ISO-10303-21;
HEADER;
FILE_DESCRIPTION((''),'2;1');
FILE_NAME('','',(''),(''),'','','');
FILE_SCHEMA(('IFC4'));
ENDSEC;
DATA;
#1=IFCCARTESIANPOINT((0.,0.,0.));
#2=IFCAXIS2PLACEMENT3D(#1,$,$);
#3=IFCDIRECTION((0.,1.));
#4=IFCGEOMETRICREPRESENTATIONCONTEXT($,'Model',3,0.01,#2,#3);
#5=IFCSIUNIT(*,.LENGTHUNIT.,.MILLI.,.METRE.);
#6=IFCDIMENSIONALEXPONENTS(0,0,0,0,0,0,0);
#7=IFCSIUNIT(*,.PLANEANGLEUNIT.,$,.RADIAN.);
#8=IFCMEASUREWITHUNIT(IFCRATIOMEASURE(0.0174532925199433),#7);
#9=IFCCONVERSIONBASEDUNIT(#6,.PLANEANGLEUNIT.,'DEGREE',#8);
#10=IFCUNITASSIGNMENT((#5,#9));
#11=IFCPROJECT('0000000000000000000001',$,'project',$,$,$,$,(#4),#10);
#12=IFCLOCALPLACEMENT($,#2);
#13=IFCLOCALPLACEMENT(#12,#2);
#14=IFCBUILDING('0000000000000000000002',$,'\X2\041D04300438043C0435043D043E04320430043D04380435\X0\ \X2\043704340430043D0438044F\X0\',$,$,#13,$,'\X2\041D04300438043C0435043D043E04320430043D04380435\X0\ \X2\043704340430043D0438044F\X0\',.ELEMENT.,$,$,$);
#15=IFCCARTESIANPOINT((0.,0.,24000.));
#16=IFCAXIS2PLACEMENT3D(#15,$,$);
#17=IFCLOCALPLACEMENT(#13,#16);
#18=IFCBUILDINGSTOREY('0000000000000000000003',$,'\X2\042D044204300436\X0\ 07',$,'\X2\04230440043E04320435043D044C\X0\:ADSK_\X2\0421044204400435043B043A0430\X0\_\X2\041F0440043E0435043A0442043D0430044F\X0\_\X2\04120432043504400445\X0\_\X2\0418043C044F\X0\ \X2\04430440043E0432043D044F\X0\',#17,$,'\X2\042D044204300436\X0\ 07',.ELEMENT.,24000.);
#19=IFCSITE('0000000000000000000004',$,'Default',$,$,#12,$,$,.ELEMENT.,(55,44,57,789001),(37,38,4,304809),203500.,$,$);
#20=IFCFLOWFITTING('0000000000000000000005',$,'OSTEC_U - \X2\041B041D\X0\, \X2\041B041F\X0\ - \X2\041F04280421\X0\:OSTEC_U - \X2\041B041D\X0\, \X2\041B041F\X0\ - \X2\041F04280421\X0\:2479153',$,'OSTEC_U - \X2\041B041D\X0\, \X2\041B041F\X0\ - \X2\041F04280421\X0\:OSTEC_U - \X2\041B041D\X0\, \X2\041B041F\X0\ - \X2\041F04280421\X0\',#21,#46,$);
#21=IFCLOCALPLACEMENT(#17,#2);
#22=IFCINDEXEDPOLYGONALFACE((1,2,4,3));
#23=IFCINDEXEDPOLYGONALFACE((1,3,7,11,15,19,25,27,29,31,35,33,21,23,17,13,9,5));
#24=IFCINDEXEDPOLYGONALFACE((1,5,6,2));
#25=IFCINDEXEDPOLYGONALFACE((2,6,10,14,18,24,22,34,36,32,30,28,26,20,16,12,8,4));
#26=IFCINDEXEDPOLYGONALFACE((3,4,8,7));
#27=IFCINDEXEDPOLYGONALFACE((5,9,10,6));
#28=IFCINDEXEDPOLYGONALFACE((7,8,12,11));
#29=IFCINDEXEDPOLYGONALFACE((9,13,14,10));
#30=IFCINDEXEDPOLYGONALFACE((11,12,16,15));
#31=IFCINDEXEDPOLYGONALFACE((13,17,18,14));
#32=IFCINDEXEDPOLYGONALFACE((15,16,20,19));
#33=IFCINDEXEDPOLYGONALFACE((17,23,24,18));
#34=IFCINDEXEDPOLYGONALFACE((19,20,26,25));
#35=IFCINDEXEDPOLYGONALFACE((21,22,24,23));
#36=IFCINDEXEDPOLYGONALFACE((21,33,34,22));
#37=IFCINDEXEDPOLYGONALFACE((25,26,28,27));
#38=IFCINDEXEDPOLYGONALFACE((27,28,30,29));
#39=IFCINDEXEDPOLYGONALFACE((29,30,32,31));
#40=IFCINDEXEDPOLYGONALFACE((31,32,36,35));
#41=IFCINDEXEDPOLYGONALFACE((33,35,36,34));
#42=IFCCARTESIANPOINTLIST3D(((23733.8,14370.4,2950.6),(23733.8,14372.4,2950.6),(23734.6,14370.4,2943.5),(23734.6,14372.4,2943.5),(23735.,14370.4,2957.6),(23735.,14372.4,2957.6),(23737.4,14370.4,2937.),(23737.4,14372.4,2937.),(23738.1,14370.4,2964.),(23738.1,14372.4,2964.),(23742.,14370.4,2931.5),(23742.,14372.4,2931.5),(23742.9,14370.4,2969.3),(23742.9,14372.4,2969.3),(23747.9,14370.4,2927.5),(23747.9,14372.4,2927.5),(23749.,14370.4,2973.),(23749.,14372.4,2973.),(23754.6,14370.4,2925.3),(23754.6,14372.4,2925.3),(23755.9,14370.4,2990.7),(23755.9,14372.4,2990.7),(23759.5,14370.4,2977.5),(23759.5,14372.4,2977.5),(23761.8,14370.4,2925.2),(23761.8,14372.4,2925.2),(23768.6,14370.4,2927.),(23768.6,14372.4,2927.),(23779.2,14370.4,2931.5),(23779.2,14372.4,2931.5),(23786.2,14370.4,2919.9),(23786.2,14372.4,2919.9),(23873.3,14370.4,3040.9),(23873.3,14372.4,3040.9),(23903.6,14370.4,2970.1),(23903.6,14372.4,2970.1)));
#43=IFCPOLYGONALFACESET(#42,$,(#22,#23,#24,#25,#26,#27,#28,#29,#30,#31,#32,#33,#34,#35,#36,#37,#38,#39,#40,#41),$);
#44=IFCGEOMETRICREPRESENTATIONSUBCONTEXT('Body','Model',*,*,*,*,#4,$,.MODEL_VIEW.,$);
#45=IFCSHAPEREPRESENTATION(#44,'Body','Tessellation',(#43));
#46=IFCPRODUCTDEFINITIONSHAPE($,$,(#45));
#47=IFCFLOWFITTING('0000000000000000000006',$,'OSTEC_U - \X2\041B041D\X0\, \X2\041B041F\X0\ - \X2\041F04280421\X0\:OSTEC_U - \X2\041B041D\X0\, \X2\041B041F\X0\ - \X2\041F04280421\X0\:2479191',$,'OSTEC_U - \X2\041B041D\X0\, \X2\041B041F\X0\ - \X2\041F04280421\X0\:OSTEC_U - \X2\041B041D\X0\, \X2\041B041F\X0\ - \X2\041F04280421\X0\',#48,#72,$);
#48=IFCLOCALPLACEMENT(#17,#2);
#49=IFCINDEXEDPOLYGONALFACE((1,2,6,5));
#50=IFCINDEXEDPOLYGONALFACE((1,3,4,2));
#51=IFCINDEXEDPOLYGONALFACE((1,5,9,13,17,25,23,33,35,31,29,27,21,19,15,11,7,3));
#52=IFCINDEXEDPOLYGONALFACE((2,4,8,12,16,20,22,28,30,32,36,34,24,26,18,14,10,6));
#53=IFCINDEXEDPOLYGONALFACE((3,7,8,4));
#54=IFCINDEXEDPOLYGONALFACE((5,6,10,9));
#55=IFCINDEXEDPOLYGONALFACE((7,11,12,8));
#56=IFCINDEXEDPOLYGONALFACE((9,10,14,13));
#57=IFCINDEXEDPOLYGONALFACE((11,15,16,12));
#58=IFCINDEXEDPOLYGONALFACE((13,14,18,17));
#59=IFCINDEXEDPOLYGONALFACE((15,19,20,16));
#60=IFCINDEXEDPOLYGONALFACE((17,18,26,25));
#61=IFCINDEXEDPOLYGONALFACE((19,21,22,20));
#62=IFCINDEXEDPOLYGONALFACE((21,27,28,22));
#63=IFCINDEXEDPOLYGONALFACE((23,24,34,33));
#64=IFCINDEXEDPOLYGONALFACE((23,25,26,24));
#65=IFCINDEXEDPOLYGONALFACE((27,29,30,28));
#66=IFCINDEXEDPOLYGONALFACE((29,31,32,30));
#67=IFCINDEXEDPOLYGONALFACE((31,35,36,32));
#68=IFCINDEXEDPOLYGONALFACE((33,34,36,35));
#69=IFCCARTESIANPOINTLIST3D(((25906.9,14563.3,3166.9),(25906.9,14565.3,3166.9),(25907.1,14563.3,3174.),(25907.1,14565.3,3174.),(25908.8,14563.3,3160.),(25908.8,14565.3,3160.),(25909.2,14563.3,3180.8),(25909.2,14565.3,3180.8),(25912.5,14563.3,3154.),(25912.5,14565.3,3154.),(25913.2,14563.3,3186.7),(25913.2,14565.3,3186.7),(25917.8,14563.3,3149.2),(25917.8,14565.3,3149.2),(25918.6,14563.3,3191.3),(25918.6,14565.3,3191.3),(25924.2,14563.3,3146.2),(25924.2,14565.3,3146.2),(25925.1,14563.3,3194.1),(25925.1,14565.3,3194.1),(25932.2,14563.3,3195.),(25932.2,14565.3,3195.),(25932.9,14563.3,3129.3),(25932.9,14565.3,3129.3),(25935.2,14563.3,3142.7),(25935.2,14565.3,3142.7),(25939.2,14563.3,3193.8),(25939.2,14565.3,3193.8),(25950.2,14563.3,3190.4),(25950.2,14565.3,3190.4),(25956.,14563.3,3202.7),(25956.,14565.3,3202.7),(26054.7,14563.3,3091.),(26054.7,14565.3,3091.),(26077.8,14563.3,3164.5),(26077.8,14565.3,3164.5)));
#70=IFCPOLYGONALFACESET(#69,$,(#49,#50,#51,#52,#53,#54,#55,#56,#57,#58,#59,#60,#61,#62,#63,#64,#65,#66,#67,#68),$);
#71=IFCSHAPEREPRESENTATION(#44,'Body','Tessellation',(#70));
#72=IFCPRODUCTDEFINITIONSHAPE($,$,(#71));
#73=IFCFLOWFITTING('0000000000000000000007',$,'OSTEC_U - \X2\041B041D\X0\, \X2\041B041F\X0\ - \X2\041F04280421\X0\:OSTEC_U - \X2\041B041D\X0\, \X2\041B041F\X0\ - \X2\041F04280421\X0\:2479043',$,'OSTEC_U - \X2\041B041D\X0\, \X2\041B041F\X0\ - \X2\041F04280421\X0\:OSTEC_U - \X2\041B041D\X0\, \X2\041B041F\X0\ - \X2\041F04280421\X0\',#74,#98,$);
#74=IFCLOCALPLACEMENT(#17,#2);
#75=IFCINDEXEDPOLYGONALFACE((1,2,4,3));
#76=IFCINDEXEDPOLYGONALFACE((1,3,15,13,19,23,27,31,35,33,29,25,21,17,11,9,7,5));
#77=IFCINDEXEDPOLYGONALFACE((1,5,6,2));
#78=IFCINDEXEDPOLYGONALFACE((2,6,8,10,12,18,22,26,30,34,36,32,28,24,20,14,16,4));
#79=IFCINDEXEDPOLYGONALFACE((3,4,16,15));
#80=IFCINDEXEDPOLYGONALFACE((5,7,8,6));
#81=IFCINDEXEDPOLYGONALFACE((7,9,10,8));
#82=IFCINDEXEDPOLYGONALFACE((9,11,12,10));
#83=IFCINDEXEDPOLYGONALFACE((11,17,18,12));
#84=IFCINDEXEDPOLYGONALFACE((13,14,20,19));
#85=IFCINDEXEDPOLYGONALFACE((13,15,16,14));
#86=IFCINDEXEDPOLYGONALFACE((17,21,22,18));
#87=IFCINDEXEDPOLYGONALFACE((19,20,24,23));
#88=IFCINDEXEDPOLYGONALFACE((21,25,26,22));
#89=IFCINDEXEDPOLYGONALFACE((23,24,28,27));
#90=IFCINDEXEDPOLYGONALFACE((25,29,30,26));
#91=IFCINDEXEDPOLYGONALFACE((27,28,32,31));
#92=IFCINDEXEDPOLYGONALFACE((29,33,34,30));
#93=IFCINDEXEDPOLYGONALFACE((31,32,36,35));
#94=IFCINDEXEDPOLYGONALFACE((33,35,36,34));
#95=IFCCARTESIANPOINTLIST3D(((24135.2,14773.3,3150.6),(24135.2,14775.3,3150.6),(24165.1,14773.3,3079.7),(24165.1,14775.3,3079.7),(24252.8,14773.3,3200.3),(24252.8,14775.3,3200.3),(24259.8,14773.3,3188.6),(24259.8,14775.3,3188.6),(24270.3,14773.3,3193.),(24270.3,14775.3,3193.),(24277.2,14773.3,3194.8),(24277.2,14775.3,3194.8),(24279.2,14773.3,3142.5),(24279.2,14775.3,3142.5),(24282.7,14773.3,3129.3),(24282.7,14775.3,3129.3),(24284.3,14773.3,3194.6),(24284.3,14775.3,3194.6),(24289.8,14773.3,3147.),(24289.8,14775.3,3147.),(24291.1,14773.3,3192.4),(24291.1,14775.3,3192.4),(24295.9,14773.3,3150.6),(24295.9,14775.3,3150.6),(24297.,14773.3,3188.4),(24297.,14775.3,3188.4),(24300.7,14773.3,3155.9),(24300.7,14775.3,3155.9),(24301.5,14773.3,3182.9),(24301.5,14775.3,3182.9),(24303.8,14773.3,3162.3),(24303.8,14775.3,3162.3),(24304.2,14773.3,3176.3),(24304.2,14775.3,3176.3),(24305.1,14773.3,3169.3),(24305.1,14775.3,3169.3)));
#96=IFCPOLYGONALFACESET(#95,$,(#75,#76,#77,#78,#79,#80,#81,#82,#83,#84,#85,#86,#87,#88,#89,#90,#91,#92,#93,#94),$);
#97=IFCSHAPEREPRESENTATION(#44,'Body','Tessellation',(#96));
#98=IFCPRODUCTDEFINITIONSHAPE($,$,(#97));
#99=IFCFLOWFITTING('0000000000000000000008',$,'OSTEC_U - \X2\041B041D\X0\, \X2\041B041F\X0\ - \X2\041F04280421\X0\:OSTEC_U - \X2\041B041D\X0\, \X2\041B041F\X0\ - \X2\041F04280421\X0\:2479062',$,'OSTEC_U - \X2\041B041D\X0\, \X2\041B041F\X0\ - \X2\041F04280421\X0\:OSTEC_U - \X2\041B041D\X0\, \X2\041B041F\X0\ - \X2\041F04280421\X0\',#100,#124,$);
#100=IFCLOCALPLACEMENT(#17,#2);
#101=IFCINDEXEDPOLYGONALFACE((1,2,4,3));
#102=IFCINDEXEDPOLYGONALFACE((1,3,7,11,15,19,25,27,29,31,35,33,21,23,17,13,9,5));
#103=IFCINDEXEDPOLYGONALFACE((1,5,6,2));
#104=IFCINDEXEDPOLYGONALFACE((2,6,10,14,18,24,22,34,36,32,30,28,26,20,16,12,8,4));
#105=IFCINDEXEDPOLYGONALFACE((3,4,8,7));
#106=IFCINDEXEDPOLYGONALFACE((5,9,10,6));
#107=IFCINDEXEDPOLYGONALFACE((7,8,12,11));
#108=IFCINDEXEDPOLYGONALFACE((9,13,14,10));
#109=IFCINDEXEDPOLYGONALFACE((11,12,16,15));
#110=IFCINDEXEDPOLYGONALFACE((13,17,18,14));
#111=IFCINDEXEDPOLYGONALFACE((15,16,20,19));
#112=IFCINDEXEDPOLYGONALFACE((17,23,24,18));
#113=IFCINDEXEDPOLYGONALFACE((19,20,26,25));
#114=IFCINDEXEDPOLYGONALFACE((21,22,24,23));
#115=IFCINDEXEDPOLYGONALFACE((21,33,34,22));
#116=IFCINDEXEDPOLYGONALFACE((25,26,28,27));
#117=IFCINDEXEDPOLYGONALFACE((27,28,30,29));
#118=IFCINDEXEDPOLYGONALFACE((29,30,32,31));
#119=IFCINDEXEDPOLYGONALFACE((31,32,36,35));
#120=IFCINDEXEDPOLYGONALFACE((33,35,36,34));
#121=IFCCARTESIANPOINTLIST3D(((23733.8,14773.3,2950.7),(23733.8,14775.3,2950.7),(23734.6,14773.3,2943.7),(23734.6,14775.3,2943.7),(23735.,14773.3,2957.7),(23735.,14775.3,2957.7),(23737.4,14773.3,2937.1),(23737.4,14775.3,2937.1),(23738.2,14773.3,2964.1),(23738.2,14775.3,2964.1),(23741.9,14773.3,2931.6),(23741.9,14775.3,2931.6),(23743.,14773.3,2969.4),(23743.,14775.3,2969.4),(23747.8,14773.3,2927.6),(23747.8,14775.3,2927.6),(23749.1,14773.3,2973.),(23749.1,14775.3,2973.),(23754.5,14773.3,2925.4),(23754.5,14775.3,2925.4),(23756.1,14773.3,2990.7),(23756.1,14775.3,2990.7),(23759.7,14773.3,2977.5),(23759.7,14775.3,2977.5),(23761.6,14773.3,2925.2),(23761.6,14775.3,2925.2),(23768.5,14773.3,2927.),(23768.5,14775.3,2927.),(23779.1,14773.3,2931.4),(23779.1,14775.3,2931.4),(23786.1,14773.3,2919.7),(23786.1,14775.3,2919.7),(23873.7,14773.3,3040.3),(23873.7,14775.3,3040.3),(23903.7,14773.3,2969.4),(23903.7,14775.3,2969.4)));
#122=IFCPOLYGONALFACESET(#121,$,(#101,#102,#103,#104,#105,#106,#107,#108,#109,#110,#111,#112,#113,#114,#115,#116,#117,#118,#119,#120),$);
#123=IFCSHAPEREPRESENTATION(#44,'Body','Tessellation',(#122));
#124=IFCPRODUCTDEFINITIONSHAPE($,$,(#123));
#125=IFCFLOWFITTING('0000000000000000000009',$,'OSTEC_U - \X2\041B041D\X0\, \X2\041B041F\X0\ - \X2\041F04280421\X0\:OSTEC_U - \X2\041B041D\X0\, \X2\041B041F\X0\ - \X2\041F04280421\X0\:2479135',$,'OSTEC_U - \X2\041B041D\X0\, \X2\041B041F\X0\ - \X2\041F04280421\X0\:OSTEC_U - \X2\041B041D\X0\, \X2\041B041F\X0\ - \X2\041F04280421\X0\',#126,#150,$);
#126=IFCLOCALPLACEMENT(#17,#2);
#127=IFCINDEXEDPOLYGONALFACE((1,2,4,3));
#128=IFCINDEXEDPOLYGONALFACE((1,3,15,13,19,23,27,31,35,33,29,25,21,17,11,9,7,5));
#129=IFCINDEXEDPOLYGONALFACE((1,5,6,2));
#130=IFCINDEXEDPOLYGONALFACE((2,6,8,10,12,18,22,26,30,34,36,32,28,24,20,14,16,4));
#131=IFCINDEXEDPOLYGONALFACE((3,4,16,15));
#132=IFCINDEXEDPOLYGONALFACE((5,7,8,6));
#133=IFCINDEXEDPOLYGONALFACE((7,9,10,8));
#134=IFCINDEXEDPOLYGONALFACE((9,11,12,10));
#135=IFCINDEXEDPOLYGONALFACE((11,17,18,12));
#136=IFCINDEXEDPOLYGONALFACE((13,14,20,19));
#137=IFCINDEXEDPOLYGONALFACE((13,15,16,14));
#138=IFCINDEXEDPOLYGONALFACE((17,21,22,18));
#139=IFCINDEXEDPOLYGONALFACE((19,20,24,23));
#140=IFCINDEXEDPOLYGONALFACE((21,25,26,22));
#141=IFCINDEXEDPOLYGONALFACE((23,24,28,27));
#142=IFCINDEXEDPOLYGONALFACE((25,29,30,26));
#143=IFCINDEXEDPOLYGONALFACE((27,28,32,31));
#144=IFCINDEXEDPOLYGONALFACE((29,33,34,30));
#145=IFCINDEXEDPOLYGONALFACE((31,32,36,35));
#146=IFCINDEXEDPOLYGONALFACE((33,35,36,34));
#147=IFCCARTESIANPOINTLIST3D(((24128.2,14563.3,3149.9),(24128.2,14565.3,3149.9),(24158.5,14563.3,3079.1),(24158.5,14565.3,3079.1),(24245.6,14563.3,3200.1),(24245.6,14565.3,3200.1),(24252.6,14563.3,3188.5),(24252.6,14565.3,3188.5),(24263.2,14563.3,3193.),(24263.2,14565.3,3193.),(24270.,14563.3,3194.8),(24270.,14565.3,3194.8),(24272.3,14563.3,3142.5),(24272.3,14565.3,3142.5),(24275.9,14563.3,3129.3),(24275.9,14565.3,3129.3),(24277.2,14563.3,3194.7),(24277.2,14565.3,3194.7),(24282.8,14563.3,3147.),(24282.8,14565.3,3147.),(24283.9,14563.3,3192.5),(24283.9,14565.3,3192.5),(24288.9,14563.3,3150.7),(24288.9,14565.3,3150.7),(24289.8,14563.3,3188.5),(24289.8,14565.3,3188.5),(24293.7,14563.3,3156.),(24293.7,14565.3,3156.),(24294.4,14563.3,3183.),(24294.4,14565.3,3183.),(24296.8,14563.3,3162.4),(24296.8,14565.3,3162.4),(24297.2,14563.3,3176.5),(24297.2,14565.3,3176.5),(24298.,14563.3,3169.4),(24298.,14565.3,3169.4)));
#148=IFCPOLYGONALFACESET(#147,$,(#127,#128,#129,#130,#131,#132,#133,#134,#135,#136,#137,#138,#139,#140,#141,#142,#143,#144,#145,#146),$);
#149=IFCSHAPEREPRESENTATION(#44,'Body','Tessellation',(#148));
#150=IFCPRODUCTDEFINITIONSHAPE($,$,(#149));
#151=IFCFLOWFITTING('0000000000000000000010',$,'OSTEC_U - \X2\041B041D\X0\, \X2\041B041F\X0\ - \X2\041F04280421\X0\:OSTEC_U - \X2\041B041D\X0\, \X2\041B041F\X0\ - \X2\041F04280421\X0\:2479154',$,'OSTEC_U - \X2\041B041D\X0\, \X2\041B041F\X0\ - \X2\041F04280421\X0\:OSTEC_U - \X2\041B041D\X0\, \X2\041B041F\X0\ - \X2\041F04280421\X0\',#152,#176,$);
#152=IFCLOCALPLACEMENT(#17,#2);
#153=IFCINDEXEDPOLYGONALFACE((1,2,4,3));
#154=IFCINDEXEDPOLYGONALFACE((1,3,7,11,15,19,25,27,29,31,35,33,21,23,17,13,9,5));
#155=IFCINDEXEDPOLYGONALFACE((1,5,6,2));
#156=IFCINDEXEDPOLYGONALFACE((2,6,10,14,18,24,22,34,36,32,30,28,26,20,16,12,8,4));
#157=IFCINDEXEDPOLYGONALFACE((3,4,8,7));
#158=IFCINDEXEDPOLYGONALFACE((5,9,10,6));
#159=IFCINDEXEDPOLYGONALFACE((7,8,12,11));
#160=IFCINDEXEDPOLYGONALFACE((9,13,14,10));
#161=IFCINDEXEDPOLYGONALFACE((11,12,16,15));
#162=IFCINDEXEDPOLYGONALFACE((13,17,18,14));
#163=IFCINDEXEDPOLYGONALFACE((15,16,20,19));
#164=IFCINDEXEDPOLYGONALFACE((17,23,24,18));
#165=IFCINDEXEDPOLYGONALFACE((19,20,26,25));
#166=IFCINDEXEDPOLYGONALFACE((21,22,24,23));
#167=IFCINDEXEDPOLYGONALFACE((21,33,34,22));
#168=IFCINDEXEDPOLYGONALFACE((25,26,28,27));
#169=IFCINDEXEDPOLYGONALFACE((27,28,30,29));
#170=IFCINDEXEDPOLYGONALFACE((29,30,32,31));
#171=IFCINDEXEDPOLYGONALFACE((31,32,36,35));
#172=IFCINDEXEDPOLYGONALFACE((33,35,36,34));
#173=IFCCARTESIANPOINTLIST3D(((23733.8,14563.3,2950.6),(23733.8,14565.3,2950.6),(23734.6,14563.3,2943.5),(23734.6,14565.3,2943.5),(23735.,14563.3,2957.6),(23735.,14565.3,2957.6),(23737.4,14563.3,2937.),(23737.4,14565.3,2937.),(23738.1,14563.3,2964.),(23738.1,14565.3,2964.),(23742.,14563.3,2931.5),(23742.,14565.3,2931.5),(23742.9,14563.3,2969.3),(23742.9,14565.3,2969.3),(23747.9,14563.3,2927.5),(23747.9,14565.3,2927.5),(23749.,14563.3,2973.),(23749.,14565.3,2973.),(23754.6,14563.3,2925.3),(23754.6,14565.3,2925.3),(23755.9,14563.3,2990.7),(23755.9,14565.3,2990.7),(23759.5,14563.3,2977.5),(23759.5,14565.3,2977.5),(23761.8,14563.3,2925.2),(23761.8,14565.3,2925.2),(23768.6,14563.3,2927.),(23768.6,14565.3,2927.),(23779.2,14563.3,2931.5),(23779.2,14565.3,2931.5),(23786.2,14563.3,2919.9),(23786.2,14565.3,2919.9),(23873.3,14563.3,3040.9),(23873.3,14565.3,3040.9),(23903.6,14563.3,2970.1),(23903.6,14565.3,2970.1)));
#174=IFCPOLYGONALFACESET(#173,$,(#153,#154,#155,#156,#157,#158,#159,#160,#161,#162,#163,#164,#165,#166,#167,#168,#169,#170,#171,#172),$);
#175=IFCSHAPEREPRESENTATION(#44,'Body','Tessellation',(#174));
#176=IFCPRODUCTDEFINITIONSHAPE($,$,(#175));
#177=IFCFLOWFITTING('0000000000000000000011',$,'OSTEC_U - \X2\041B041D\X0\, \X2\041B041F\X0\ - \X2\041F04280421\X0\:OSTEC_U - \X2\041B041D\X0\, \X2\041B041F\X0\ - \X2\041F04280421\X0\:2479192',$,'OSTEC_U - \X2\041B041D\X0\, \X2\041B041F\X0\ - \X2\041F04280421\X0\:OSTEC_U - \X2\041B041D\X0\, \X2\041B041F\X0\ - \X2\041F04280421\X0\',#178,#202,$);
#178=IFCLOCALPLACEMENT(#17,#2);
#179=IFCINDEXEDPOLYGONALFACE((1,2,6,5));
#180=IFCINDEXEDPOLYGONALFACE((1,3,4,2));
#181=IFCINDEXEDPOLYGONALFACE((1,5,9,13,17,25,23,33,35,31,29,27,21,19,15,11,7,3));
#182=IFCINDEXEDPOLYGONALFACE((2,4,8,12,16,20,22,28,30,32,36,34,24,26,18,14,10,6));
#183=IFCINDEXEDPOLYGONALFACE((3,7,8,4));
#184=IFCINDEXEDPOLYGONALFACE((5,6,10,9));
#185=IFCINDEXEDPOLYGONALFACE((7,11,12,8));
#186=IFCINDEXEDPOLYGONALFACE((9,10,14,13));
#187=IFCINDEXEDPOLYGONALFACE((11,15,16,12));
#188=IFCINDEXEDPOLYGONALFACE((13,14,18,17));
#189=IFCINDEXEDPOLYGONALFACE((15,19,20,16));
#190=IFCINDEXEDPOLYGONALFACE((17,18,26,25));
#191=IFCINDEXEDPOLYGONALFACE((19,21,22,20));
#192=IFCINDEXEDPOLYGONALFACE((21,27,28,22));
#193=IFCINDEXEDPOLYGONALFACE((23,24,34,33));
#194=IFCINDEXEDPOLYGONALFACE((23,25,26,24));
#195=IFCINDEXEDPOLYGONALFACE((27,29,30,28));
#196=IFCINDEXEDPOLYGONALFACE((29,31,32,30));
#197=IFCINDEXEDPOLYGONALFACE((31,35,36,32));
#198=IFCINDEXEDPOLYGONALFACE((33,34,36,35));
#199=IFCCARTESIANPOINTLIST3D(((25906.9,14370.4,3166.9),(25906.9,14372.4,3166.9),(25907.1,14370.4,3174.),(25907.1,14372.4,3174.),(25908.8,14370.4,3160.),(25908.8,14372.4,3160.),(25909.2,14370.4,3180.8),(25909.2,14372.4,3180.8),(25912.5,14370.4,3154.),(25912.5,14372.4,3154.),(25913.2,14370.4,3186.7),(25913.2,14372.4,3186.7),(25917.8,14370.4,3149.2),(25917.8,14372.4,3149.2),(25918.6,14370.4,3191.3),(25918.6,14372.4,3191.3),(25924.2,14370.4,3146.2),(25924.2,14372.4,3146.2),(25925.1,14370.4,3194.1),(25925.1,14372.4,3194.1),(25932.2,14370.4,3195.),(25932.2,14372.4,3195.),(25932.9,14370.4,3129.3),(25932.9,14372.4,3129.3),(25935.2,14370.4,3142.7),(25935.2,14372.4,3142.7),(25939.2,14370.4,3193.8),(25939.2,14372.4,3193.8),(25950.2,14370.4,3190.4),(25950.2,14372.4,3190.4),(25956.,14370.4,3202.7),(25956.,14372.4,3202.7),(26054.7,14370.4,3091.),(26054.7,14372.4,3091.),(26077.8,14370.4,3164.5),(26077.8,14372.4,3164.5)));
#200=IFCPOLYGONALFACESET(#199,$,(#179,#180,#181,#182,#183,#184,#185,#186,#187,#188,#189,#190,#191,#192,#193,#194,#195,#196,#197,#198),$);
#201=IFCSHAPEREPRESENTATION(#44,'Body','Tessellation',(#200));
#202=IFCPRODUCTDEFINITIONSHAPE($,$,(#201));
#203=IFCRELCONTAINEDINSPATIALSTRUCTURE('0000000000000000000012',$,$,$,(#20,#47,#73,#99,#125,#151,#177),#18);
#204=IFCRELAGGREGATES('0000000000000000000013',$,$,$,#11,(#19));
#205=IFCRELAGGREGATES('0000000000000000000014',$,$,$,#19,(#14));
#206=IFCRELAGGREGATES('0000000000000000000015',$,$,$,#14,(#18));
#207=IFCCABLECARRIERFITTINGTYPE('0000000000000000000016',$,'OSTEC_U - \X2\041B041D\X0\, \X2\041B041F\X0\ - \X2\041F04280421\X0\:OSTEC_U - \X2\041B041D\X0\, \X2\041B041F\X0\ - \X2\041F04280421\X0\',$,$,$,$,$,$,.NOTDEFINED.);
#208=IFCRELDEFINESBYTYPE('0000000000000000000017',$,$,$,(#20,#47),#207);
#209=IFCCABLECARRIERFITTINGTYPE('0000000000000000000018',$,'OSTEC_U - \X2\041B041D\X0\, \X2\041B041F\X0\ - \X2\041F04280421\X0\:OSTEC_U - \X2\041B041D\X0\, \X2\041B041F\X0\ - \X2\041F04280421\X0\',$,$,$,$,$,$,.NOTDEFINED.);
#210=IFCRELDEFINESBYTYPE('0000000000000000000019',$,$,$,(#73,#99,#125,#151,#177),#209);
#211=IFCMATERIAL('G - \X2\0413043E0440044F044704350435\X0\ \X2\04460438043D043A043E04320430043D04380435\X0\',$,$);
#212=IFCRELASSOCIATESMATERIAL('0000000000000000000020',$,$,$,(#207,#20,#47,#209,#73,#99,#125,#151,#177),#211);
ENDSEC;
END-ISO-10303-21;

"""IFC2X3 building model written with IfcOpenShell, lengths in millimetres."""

from ifc_helpers import new_model, entity, si_unit, converted_unit, direction, frame, frame_2d, origin, place, context, subcontext, project, spatial, polyline, circle_curve, parameter, trimmed, segment, composite_curve, outline, extrude, source, transform, mapped, material, type_object, type_shapes, element, save


model = new_model("IFC2X3")

# Units and contexts
model_context = context("Model", 3, precision=0.01, world=origin(), true_north=direction((0.0, 1.0)))
body_context = subcontext(model_context, "Body", "Model", "MODEL_VIEW")
ifc_project = project(units=[si_unit("LENGTHUNIT", "METRE", prefix="MILLI"), converted_unit("PLANEANGLEUNIT", "DEGREE", entity("IfcRatioMeasure", 0.0174532925199433), si_unit("PLANEANGLEUNIT", "RADIAN"), dimensions=[0, 0, 0, 0, 0, 0, 0])], contexts=[model_context])

# Site, building, storey
site_placement = place(None, frame((0.0, 0.0, 0.0)))
site = spatial("IfcSite", under=ifc_project, at=site_placement, Name="Default", CompositionType="ELEMENT", RefLatitude=(55, 44, 57, 789001), RefLongitude=(37, 38, 4, 304809), RefElevation=203500.0)
building_placement = place(site_placement, origin())
building = spatial("IfcBuilding", under=site, at=building_placement, Name="Наименование здания", LongName="Наименование здания", CompositionType="ELEMENT")
storey_placement = place(building_placement, frame((0.0, 0.0, 24000.0)))
storey = spatial("IfcBuildingStorey", under=building, at=storey_placement, Name="Этаж 07", ObjectType="Уровень:ADSK_Стрелка_Проектная_Вверх_Имя уровня", LongName="Этаж 07", CompositionType="ELEMENT", Elevation=24000.0)

# Flow fittings
ifc_material_1 = material(Name="G - Горячее цинкование")
cable_carrier_fitting_type_1 = type_object("IfcCableCarrierFittingType", Name="OSTEC_U - ЛН, ЛП - ПШС:OSTEC_U - ЛН, ЛП - ПШС", PredefinedType="NOTDEFINED", material=ifc_material_1)
shared_shape_1 = source(origin(), body_context, "Body", "SweptSolid", [
    extrude(outline(composite_curve([segment(trimmed(circle_curve(frame_2d((-41.5, 0.0), x_axis=(1.0, 0.0)), 25.0), [parameter(90.0)], [parameter(270.0)], True, "PARAMETER"), True, "CONTINUOUS"), segment(polyline([(-41.5, -25.0), (-30.0, -25.0)]), True, "CONTINUOUS"), segment(polyline([(-30.0, -25.0), (-28.1, -38.5)]), True, "CONTINUOUS"), segment(polyline([(-28.1, -38.5), (99.5, -38.5)]), True, "CONTINUOUS"), segment(polyline([(99.5, -38.5), (99.5, 38.5)]), True, "CONTINUOUS"), segment(polyline([(99.5, 38.5), (-28.1, 38.5)]), True, "CONTINUOUS"), segment(polyline([(-28.1, 38.5), (-30.0, 25.0)]), True, "CONTINUOUS"), segment(polyline([(-30.0, 25.0), (-41.5, 25.0)]), True, "CONTINUOUS")], self_intersect=False)), frame((41.5, 0.0, 0.0), z_axis=(0.0, 0.0, -1.0), x_axis=(1.0, 0.0, 0.0)), (0.0, 0.0, -1.0), 2.0),
])
type_shapes(cable_carrier_fitting_type_1, [shared_shape_1])
for number, where, z_axis, x_axis, name in (
    (1, (23758.8, 14372.4, 2950.0), (0.0, -1.0, 0.0), (0.919387, 0.0, 0.393354), "OSTEC_U - ЛН, ЛП - ПШС:OSTEC_U - ЛН, ЛП - ПШС:2479153"),
    (2, (25931.7, 14563.3, 3170.0), (0.0, 1.0, 0.0), (0.953994, 0.0, -0.299827), "OSTEC_U - ЛН, ЛП - ПШС:OSTEC_U - ЛН, ЛП - ПШС:2479191"),
):
    element("IfcFlowFitting", number, at=place(storey_placement, frame(where, z_axis=z_axis, x_axis=x_axis)), inside=storey, type_object=cable_carrier_fitting_type_1, material=ifc_material_1, Name=name, ObjectType="OSTEC_U - ЛН, ЛП - ПШС:OSTEC_U - ЛН, ЛП - ПШС", context=body_context, shape_type="MappedRepresentation", body=[
        mapped(shared_shape_1, transform((0.0, 0.0, 0.0), scale=1.0)),
    ])
cable_carrier_fitting_type_2 = type_object("IfcCableCarrierFittingType", Name="OSTEC_U - ЛН, ЛП - ПШС:OSTEC_U - ЛН, ЛП - ПШС", PredefinedType="NOTDEFINED", material=ifc_material_1)
shared_shape_2 = source(origin(), body_context, "Body", "SweptSolid", [
    extrude(outline(composite_curve([segment(trimmed(circle_curve(frame_2d((-41.5, 0.0), x_axis=(1.0, 0.0)), 25.0), [parameter(90.0)], [parameter(270.0)], True, "PARAMETER"), True, "CONTINUOUS"), segment(polyline([(-41.5, -25.0), (-30.0, -25.0)]), True, "CONTINUOUS"), segment(polyline([(-30.0, -25.0), (-28.1, -38.5)]), True, "CONTINUOUS"), segment(polyline([(-28.1, -38.5), (99.5, -38.5)]), True, "CONTINUOUS"), segment(polyline([(99.5, -38.5), (99.5, 38.5)]), True, "CONTINUOUS"), segment(polyline([(99.5, 38.5), (-28.1, 38.5)]), True, "CONTINUOUS"), segment(polyline([(-28.1, 38.5), (-30.0, 25.0)]), True, "CONTINUOUS"), segment(polyline([(-30.0, 25.0), (-41.5, 25.0)]), True, "CONTINUOUS")], self_intersect=False)), frame((41.5, 0.0, 0.0)), (0.0, 0.0, 1.0), 2.0),
])
type_shapes(cable_carrier_fitting_type_2, [shared_shape_2])
for number, where, z_axis, x_axis, name in (
    (3, (24280.1, 14773.3, 3170.0), (0.0, 1.0, 0.0), (-0.921308, 0.0, -0.388834), "OSTEC_U - ЛН, ЛП - ПШС:OSTEC_U - ЛН, ЛП - ПШС:2479043"),
    (4, (23758.8, 14773.3, 2950.0), (0.0, 1.0, 0.0), (0.921308, 0.0, 0.388834), "OSTEC_U - ЛН, ЛП - ПШС:OSTEC_U - ЛН, ЛП - ПШС:2479062"),
    (5, (24273.0, 14563.3, 3170.0), (0.0, 1.0, 0.0), (-0.919387, 0.0, -0.393354), "OSTEC_U - ЛН, ЛП - ПШС:OSTEC_U - ЛН, ЛП - ПШС:2479135"),
    (6, (23758.8, 14563.3, 2950.0), (0.0, 1.0, 0.0), (0.919387, 0.0, 0.393354), "OSTEC_U - ЛН, ЛП - ПШС:OSTEC_U - ЛН, ЛП - ПШС:2479154"),
    (7, (25931.7, 14372.4, 3170.0), (0.0, -1.0, 0.0), (0.953994, 0.0, -0.299827), "OSTEC_U - ЛН, ЛП - ПШС:OSTEC_U - ЛН, ЛП - ПШС:2479192"),
):
    element("IfcFlowFitting", number, at=place(storey_placement, frame(where, z_axis=z_axis, x_axis=x_axis)), inside=storey, type_object=cable_carrier_fitting_type_2, material=ifc_material_1, Name=name, ObjectType="OSTEC_U - ЛН, ЛП - ПШС:OSTEC_U - ЛН, ЛП - ПШС", context=body_context, shape_type="MappedRepresentation", body=[
        mapped(shared_shape_2, transform((0.0, 0.0, 0.0), scale=1.0)),
    ])

save(model, "model.ifc")
